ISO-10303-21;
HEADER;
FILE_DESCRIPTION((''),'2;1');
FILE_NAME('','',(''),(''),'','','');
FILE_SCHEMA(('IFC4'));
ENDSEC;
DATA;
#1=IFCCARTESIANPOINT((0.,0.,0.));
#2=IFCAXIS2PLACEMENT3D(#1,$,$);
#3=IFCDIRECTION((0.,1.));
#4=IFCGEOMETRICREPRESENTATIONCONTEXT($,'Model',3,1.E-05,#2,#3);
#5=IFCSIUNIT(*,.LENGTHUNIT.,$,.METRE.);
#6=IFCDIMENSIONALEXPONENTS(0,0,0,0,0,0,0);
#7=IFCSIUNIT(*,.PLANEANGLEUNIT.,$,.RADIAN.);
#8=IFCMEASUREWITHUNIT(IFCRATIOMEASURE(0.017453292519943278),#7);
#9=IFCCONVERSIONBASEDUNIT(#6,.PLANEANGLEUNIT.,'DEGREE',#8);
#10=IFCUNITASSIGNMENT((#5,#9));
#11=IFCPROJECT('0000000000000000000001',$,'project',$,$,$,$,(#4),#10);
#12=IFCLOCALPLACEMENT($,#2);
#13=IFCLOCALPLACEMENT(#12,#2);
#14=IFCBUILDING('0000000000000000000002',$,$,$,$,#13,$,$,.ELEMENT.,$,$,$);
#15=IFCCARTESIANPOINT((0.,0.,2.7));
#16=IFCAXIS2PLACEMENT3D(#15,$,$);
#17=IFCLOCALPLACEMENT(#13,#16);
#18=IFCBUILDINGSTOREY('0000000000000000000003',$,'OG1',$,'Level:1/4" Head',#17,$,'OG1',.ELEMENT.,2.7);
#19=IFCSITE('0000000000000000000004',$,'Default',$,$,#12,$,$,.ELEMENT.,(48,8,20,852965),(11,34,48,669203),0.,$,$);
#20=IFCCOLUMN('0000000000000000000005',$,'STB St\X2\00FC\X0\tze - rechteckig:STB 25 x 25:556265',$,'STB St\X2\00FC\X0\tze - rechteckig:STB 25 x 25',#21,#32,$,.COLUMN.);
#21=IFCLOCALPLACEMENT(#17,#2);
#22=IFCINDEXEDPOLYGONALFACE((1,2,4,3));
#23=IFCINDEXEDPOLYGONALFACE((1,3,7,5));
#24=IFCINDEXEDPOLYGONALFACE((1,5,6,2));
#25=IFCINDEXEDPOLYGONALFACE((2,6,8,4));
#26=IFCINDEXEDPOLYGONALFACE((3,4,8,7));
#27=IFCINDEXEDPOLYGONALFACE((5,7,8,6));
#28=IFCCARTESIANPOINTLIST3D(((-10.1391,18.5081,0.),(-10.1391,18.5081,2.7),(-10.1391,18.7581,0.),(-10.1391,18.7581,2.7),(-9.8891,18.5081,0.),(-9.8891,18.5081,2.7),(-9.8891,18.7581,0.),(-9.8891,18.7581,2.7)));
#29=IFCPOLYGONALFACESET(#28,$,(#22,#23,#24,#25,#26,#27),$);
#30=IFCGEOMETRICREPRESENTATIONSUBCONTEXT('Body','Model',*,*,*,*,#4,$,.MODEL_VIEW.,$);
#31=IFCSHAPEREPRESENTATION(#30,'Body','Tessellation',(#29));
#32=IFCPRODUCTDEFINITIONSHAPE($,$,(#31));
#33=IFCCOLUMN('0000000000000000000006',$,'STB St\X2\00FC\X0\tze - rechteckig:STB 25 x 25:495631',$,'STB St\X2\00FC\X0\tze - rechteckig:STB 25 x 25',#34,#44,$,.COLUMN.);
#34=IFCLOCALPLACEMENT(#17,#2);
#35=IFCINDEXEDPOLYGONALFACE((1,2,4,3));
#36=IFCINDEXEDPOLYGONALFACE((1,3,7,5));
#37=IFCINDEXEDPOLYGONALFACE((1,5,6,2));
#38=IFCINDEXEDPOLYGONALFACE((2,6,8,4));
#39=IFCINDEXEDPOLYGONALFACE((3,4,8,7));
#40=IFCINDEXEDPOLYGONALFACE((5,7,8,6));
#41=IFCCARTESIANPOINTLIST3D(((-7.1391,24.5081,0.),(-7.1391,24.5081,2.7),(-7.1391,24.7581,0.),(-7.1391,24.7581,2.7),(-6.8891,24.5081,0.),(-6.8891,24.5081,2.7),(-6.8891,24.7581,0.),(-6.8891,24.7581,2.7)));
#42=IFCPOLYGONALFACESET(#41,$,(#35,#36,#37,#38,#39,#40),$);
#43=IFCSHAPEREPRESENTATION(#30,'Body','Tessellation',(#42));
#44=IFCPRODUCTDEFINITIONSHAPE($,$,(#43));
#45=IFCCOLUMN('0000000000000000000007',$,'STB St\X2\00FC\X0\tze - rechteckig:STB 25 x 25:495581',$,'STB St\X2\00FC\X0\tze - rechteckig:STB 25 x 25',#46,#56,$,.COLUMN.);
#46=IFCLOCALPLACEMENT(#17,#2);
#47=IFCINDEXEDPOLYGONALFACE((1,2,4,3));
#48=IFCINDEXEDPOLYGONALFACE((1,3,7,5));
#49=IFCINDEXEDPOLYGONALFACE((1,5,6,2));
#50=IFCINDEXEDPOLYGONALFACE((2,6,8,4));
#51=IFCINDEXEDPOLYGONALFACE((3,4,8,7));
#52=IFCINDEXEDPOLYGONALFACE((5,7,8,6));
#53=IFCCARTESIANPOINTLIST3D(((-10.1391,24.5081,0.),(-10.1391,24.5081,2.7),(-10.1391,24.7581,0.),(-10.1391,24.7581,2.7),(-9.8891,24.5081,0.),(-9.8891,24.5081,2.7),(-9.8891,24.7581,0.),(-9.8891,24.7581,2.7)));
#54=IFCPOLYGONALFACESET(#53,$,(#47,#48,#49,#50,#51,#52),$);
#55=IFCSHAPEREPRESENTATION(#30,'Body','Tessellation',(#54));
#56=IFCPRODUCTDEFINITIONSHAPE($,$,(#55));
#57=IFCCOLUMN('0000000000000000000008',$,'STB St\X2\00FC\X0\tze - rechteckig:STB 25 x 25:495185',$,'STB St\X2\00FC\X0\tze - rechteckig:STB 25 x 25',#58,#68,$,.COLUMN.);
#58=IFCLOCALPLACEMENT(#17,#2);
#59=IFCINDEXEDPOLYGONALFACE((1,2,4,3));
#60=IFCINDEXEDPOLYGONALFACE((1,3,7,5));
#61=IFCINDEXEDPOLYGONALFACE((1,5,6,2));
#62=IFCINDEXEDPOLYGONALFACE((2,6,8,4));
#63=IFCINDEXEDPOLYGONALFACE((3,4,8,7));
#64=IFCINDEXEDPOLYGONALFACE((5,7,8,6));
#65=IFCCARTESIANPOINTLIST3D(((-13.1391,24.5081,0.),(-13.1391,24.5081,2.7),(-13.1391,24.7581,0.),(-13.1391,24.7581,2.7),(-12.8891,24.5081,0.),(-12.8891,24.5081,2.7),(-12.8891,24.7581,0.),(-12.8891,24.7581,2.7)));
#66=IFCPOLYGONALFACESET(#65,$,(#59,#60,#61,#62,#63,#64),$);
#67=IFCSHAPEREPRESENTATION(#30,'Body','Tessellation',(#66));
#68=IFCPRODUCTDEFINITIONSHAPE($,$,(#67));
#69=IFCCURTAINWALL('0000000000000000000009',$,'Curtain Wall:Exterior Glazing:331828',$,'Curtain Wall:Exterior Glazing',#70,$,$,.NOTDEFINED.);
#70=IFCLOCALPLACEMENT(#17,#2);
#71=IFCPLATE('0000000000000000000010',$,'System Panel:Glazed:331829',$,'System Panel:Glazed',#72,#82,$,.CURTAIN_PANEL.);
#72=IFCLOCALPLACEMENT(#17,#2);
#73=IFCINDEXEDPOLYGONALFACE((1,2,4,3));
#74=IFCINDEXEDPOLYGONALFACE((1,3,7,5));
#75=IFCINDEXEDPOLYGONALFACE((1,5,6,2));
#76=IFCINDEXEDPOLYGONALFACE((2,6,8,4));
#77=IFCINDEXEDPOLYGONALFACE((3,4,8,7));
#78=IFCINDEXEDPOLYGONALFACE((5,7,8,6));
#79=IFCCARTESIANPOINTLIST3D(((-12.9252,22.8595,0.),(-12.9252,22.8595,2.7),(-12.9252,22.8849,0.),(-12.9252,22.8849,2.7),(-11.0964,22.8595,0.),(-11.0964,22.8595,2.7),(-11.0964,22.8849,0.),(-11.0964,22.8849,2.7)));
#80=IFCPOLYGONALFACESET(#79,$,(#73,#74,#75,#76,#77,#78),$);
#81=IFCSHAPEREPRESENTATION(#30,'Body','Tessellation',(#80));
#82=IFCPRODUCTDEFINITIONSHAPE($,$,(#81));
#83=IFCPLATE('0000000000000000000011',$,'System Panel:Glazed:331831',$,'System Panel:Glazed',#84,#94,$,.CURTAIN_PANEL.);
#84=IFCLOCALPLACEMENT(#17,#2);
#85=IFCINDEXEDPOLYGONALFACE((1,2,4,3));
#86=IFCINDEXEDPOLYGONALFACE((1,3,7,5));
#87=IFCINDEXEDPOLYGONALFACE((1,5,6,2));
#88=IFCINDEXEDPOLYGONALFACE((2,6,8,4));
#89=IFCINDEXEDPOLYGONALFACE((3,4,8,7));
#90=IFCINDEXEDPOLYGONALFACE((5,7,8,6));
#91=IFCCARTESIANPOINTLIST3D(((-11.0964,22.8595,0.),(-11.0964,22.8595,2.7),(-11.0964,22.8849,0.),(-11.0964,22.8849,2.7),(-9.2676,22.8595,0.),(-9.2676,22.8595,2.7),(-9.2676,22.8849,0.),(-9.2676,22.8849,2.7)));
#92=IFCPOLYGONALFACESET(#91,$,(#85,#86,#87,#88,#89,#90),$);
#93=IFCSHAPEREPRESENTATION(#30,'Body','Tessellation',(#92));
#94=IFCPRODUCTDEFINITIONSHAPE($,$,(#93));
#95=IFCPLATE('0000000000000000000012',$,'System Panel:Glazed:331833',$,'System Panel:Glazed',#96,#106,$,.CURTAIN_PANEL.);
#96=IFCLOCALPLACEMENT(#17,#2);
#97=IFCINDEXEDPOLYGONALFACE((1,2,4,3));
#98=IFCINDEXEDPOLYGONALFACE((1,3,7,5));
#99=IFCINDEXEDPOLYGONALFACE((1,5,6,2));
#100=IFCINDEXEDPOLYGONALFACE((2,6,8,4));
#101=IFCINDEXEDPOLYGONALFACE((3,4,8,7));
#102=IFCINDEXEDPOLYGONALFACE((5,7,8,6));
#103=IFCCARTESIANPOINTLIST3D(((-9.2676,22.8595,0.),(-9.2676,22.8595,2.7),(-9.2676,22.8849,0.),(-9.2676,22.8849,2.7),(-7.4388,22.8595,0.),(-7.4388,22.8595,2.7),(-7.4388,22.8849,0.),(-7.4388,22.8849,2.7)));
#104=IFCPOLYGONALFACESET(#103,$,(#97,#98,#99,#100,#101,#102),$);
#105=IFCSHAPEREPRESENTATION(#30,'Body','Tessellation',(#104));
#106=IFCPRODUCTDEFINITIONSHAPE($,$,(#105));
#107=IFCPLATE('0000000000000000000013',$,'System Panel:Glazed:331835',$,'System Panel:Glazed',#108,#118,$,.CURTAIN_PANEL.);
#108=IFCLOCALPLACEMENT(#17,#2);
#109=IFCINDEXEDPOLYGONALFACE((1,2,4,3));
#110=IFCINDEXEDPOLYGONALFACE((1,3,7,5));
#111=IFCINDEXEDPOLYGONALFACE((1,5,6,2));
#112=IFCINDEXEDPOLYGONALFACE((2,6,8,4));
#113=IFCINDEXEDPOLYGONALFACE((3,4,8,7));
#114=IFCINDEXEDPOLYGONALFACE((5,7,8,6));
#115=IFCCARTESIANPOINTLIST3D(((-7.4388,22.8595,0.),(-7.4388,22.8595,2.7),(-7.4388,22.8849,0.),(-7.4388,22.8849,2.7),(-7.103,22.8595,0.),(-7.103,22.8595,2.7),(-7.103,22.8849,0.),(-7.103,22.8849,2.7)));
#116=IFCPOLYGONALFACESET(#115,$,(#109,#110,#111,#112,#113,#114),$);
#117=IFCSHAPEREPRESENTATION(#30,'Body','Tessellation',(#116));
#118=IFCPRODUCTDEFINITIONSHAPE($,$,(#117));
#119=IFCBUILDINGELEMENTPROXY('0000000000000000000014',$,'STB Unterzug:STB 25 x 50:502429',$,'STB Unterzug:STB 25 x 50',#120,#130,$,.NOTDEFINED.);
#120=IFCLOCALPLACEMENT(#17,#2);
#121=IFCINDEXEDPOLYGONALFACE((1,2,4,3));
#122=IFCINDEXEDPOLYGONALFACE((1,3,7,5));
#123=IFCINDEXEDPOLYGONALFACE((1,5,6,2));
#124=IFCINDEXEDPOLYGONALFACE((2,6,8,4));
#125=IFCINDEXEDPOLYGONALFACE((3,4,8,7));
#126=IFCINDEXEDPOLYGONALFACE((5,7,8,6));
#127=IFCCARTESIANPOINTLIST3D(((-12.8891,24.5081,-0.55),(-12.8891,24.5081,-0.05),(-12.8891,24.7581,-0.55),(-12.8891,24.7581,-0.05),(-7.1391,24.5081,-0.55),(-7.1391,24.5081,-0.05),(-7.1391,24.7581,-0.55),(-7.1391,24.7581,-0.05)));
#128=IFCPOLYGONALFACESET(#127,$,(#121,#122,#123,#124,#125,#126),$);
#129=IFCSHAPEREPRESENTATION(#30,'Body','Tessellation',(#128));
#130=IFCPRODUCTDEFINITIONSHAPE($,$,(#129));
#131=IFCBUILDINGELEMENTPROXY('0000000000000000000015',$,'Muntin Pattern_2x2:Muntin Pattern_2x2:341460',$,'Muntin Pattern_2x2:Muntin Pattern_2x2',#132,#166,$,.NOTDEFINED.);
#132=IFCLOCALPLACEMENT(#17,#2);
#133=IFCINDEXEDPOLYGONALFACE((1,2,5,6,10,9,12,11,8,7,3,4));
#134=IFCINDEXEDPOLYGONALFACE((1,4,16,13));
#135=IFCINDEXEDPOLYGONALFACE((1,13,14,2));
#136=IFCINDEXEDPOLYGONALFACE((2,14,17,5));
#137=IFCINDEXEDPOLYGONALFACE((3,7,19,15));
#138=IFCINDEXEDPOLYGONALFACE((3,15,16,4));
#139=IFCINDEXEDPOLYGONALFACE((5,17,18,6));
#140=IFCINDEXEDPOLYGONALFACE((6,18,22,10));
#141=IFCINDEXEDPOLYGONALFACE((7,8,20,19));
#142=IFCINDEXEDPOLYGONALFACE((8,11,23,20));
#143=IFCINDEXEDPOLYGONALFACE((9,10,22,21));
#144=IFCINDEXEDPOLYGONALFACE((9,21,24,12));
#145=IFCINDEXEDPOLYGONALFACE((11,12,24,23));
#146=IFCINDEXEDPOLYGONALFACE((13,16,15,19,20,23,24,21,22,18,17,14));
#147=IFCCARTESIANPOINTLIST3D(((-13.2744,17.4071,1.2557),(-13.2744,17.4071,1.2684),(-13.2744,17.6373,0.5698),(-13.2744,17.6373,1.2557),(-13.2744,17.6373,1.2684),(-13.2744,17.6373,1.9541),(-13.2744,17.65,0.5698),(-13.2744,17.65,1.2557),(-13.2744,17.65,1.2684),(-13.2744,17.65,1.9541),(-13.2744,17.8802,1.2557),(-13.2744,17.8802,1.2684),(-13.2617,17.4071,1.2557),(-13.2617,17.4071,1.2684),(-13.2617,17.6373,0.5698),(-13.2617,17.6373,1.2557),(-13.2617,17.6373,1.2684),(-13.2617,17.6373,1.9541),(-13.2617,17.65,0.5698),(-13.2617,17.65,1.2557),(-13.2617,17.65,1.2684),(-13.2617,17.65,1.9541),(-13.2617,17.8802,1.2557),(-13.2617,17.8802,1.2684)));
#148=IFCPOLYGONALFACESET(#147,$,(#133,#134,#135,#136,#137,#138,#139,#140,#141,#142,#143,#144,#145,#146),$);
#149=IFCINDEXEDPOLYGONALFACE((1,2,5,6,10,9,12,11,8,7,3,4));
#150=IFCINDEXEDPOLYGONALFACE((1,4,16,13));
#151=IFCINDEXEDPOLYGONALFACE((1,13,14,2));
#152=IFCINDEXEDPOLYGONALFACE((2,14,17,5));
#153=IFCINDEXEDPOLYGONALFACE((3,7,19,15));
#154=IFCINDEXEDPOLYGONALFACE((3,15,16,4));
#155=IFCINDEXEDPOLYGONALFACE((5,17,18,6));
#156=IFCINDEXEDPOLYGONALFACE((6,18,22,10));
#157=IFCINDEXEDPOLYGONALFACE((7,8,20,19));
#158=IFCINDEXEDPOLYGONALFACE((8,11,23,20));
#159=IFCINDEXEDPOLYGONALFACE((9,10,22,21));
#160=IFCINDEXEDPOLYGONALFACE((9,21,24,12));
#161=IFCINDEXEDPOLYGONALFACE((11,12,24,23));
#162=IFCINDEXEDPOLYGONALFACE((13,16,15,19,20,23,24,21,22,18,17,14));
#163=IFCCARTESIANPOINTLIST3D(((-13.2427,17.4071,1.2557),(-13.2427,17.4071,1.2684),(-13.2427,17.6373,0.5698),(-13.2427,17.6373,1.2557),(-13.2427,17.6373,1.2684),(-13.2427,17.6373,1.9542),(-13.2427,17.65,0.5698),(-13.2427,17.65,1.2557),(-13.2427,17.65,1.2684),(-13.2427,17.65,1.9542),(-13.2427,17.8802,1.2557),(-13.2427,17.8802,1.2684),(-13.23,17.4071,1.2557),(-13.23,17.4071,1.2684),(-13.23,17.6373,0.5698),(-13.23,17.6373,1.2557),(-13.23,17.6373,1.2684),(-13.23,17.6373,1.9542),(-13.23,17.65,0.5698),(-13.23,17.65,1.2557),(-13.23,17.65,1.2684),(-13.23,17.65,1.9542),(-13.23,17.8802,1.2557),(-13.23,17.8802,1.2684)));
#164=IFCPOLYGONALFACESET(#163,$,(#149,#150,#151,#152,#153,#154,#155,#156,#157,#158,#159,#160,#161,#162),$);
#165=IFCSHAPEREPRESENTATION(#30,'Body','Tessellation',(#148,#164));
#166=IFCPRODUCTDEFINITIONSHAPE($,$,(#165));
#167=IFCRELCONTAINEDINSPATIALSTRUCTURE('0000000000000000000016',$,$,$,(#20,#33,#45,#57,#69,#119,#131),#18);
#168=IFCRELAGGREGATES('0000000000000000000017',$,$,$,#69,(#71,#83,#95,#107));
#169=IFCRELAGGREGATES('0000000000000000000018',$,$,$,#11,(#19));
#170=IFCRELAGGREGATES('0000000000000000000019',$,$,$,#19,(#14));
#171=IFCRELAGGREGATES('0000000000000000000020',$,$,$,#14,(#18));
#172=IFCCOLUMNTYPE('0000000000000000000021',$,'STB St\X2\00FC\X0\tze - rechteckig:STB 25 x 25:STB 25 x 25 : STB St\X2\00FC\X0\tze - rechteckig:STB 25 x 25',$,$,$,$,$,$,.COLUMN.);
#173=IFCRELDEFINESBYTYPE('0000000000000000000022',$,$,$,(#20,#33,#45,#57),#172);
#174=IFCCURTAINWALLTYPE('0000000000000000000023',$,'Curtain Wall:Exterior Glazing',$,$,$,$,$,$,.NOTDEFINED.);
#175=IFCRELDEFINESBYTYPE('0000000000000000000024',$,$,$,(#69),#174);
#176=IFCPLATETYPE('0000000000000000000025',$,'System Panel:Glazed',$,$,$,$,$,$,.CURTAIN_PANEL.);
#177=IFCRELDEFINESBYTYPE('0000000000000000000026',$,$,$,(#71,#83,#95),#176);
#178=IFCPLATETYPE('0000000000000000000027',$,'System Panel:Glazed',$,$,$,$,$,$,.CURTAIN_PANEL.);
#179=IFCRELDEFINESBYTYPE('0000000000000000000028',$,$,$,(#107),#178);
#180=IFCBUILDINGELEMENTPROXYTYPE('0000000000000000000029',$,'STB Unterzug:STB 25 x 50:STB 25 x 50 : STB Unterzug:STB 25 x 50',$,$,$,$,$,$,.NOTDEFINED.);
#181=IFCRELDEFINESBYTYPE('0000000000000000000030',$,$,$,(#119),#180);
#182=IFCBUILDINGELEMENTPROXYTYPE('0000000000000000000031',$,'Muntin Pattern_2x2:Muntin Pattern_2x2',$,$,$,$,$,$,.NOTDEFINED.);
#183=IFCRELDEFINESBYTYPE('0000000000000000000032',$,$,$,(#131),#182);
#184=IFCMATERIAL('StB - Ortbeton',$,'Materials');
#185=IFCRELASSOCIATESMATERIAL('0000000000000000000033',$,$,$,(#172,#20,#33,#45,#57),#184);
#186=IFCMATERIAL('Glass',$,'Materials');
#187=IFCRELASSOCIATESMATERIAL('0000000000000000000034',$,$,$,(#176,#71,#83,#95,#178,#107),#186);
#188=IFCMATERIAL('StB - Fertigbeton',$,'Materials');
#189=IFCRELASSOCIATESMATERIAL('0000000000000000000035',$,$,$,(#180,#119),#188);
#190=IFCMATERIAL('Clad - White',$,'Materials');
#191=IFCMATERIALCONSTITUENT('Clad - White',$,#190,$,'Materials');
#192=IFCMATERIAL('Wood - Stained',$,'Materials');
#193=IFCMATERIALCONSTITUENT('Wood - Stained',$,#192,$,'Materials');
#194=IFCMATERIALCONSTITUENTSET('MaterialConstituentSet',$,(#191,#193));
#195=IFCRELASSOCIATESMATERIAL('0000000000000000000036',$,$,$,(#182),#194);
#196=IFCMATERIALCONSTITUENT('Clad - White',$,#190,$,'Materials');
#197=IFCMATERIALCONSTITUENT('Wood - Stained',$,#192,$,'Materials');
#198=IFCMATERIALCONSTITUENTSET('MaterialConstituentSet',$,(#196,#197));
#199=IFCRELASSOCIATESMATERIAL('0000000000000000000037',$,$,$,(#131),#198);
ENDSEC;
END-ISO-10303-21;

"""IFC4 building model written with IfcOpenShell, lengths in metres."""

from ifc_helpers import new_model, entity, si_unit, converted_unit, direction, frame, origin, place, context, subcontext, project, spatial, indexed_curve, outline, extrude, source, transform, mapped, material, constituent, constituent_set, type_object, type_shapes, element, aggregate, save


model = new_model("IFC4")

# Units and contexts
model_context = context("Model", 3, precision=1e-05, world=origin(), true_north=direction((0.0, 1.0)))
body_context = subcontext(model_context, "Body", "Model", "MODEL_VIEW")
ifc_project = project(units=[si_unit("LENGTHUNIT", "METRE"), converted_unit("PLANEANGLEUNIT", "DEGREE", entity("IfcRatioMeasure", 0.017453292519943278), si_unit("PLANEANGLEUNIT", "RADIAN"), dimensions=[0, 0, 0, 0, 0, 0, 0])], contexts=[model_context])

# Site, building, storey
site_placement = place(None, origin())
site = spatial("IfcSite", under=ifc_project, at=site_placement, Name="Default", CompositionType="ELEMENT", RefLatitude=(48, 8, 20, 852965), RefLongitude=(11, 34, 48, 669203), RefElevation=0.0)
building_placement = place(site_placement, origin())
building = spatial("IfcBuilding", under=site, at=building_placement, CompositionType="ELEMENT")
storey_placement = place(building_placement, frame((0.0, 0.0, 2.7)))
storey = spatial("IfcBuildingStorey", under=building, at=storey_placement, Name="OG1", ObjectType="Level:1/4\" Head", LongName="OG1", CompositionType="ELEMENT", Elevation=2.7)

# Columns
ifc_material_1 = material(Name="StB - Ortbeton", Category="Materials")
column_type = type_object("IfcColumnType", Name="STB Stütze - rechteckig:STB 25 x 25:STB 25 x 25 : STB Stütze - rechteckig:STB 25 x 25", PredefinedType="COLUMN", material=ifc_material_1)
shared_shape_1 = source(origin(), body_context, "Body", "SweptSolid", [
    extrude(outline(indexed_curve([(-0.125, -0.125), (0.125, -0.125), (0.125, 0.125), (-0.125, 0.125), (-0.125, -0.125)], self_intersect=False)), frame((0.0, 0.0, 2.7), z_axis=(0.0, 0.0, 1.0), x_axis=(0.0, -1.0, 0.0)), (0.0, 0.0, 1.0), 2.7),
])
type_shapes(column_type, [shared_shape_1])
for number, where, name in (
    (1, (-10.0141, 18.6331, -2.7), "STB Stütze - rechteckig:STB 25 x 25:556265"),
    (2, (-7.0141, 24.6331, -2.7), "STB Stütze - rechteckig:STB 25 x 25:495631"),
    (3, (-10.0141, 24.6331, -2.7), "STB Stütze - rechteckig:STB 25 x 25:495581"),
    (4, (-13.0141, 24.6331, -2.7), "STB Stütze - rechteckig:STB 25 x 25:495185"),
):
    element("IfcColumn", number, at=place(storey_placement, frame(where)), inside=storey, type_object=column_type, material=ifc_material_1, Name=name, ObjectType="STB Stütze - rechteckig:STB 25 x 25", PredefinedType="COLUMN", context=body_context, shape_type="MappedRepresentation", body=[
        mapped(shared_shape_1, transform((0.0, 0.0, 0.0), scale=1.0)),
    ])

# Curtain wall, plates
curtain_wall_type = type_object("IfcCurtainWallType", Name="Curtain Wall:Exterior Glazing", PredefinedType="NOTDEFINED")
curtain_wall_placement = place(storey_placement, frame((0.0, 0.0, -2.7)))
curtain_wall = element("IfcCurtainWall", 5, at=curtain_wall_placement, inside=storey, type_object=curtain_wall_type, Name="Curtain Wall:Exterior Glazing:331828", ObjectType="Curtain Wall:Exterior Glazing", PredefinedType="NOTDEFINED")
ifc_material_2 = material(Name="Glass", Category="Materials")
plate_type_1 = type_object("IfcPlateType", Name="System Panel:Glazed", PredefinedType="CURTAIN_PANEL", material=ifc_material_2)
shared_shape_2 = source(origin(), body_context, "Body", "SweptSolid", [
    extrude(outline(indexed_curve([(-0.0127, -0.9144), (0.0127, -0.9144), (0.0127, 0.9144), (-0.0127, 0.9144), (-0.0127, -0.9144)], self_intersect=False)), frame((0.0, 0.0317, 0.0), z_axis=(0.0, 0.0, 1.0), x_axis=(0.0, 1.0, 0.0)), (0.0, 0.0, 1.0), 2.7),
])
type_shapes(plate_type_1, [shared_shape_2])
plate_1_placement = place(curtain_wall_placement, frame((-12.0108, 22.8405, 2.7)))
plate_1 = element("IfcPlate", 6, at=plate_1_placement, type_object=plate_type_1, material=ifc_material_2, Name="System Panel:Glazed:331829", ObjectType="System Panel:Glazed", PredefinedType="CURTAIN_PANEL", context=body_context, shape_type="MappedRepresentation", body=[
    mapped(shared_shape_2, transform((0.0, 0.0, 0.0), scale=1.0)),
])
plate_2_placement = place(curtain_wall_placement, frame((-10.182, 22.8405, 2.7)))
plate_2 = element("IfcPlate", 7, at=plate_2_placement, type_object=plate_type_1, material=ifc_material_2, Name="System Panel:Glazed:331831", ObjectType="System Panel:Glazed", PredefinedType="CURTAIN_PANEL", context=body_context, shape_type="MappedRepresentation", body=[
    mapped(shared_shape_2, transform((0.0, 0.0, 0.0), scale=1.0)),
])
plate_3_placement = place(curtain_wall_placement, frame((-8.3532, 22.8405, 2.7)))
plate_3 = element("IfcPlate", 8, at=plate_3_placement, type_object=plate_type_1, material=ifc_material_2, Name="System Panel:Glazed:331833", ObjectType="System Panel:Glazed", PredefinedType="CURTAIN_PANEL", context=body_context, shape_type="MappedRepresentation", body=[
    mapped(shared_shape_2, transform((0.0, 0.0, 0.0), scale=1.0)),
])
plate_type_2 = type_object("IfcPlateType", Name="System Panel:Glazed", PredefinedType="CURTAIN_PANEL", material=ifc_material_2)
shared_shape_3 = source(origin(), body_context, "Body", "SweptSolid", [
    extrude(outline(indexed_curve([(-0.0127, -0.1679), (0.0127, -0.1679), (0.0127, 0.1679), (-0.0127, 0.1679), (-0.0127, -0.1679)], self_intersect=False)), frame((0.0, 0.0318, 0.0), z_axis=(0.0, 0.0, 1.0), x_axis=(0.0, 1.0, 0.0)), (0.0, 0.0, 1.0), 2.7),
])
type_shapes(plate_type_2, [shared_shape_3])
plate_4_placement = place(curtain_wall_placement, frame((-7.2709, 22.8405, 2.7)))
plate_4 = element("IfcPlate", 9, at=plate_4_placement, type_object=plate_type_2, material=ifc_material_2, Name="System Panel:Glazed:331835", ObjectType="System Panel:Glazed", PredefinedType="CURTAIN_PANEL", context=body_context, shape_type="MappedRepresentation", body=[
    mapped(shared_shape_3, transform((0.0, 0.0, 0.0), scale=1.0)),
])
aggregate(curtain_wall, [plate_1, plate_2, plate_3, plate_4])

# Building element proxies
ifc_material_3 = material(Name="StB - Fertigbeton", Category="Materials")
building_element_proxy_type_1 = type_object("IfcBuildingElementProxyType", Name="STB Unterzug:STB 25 x 50:STB 25 x 50 : STB Unterzug:STB 25 x 50", PredefinedType="NOTDEFINED", material=ifc_material_3)
shared_shape_4 = source(origin(), body_context, "Body", "SweptSolid", [
    extrude(outline(indexed_curve([(-2.875, -0.125), (2.875, -0.125), (2.875, 0.125), (-2.875, 0.125), (-2.875, -0.125)], self_intersect=False)), frame((0.0, 0.0, -0.25), z_axis=(0.0, 0.0, 1.0), x_axis=(-1.0, 0.0, 0.0)), (0.0, 0.0, 1.0), 0.5),
])
type_shapes(building_element_proxy_type_1, [shared_shape_4])
proxy_1_placement = place(storey_placement, frame((-10.0141, 24.6331, -0.3)))
element("IfcBuildingElementProxy", 10, at=proxy_1_placement, inside=storey, type_object=building_element_proxy_type_1, material=ifc_material_3, Name="STB Unterzug:STB 25 x 50:502429", ObjectType="STB Unterzug:STB 25 x 50", PredefinedType="NOTDEFINED", context=body_context, shape_type="MappedRepresentation", body=[
    mapped(shared_shape_4, transform((0.0, 0.0, 0.0), scale=1.0)),
])
ifc_material_4 = material(Name="Clad - White", Category="Materials")
ifc_constituent_1 = constituent(ifc_material_4, Name="Clad - White", Category="Materials")
ifc_material_5 = material(Name="Wood - Stained", Category="Materials")
ifc_constituent_2 = constituent(ifc_material_5, Name="Wood - Stained", Category="Materials")
ifc_constituent_set_1 = constituent_set(constituents=[ifc_constituent_1, ifc_constituent_2], Name="MaterialConstituentSet")
ifc_constituent_3 = constituent(ifc_material_4, Name="Clad - White", Category="Materials")
ifc_constituent_4 = constituent(ifc_material_5, Name="Wood - Stained", Category="Materials")
ifc_constituent_set_2 = constituent_set(constituents=[ifc_constituent_3, ifc_constituent_4], Name="MaterialConstituentSet")
building_element_proxy_type_2 = type_object("IfcBuildingElementProxyType", Name="Muntin Pattern_2x2:Muntin Pattern_2x2", PredefinedType="NOTDEFINED", material=ifc_constituent_set_2)
shared_shape_5 = source(origin(), body_context, "Body", "SweptSolid", [
    extrude(outline(indexed_curve([(0.0064, -0.0064), (0.6921, -0.0064), (0.6921, 0.0063), (0.0064, 0.0063), (0.0064, 0.2365), (-0.0063, 0.2365), (-0.0063, 0.0063), (-0.6922, 0.0063), (-0.6922, -0.0064), (-0.0063, -0.0064), (-0.0063, -0.2365), (0.0064, -0.2365), (0.0064, -0.0064)], self_intersect=False)), frame((0.0, -0.0222, 0.6921), z_axis=(0.0, 1.0, 0.0), x_axis=(0.0, 0.0, 1.0)), (0.0, 0.0, 1.0), 0.0127),
    extrude(outline(indexed_curve([(0.0064, -0.0064), (0.6922, -0.0064), (0.6922, 0.0063), (0.0064, 0.0063), (0.0064, 0.2365), (-0.0063, 0.2365), (-0.0063, 0.0063), (-0.6922, 0.0063), (-0.6922, -0.0064), (-0.0063, -0.0064), (-0.0063, -0.2365), (0.0064, -0.2365), (0.0064, -0.0064)], self_intersect=False)), frame((0.0, 0.0095, 0.6922), z_axis=(0.0, 1.0, 0.0), x_axis=(0.0, 0.0, 1.0)), (0.0, 0.0, 1.0), 0.0127),
])
type_shapes(building_element_proxy_type_2, [shared_shape_5])
proxy_2_placement = place(storey_placement, frame((-13.2522, 17.6437, 0.5699), z_axis=(0.0, 0.0, 1.0), x_axis=(0.0, -1.0, 0.0)))
element("IfcBuildingElementProxy", 11, at=proxy_2_placement, inside=storey, type_object=building_element_proxy_type_2, material=ifc_constituent_set_1, Name="Muntin Pattern_2x2:Muntin Pattern_2x2:341460", ObjectType="Muntin Pattern_2x2:Muntin Pattern_2x2", PredefinedType="NOTDEFINED", context=body_context, shape_type="MappedRepresentation", body=[
    mapped(shared_shape_5, transform((0.0, 0.0, 0.0), scale=1.0)),
])

save(model, "model.ifc")
